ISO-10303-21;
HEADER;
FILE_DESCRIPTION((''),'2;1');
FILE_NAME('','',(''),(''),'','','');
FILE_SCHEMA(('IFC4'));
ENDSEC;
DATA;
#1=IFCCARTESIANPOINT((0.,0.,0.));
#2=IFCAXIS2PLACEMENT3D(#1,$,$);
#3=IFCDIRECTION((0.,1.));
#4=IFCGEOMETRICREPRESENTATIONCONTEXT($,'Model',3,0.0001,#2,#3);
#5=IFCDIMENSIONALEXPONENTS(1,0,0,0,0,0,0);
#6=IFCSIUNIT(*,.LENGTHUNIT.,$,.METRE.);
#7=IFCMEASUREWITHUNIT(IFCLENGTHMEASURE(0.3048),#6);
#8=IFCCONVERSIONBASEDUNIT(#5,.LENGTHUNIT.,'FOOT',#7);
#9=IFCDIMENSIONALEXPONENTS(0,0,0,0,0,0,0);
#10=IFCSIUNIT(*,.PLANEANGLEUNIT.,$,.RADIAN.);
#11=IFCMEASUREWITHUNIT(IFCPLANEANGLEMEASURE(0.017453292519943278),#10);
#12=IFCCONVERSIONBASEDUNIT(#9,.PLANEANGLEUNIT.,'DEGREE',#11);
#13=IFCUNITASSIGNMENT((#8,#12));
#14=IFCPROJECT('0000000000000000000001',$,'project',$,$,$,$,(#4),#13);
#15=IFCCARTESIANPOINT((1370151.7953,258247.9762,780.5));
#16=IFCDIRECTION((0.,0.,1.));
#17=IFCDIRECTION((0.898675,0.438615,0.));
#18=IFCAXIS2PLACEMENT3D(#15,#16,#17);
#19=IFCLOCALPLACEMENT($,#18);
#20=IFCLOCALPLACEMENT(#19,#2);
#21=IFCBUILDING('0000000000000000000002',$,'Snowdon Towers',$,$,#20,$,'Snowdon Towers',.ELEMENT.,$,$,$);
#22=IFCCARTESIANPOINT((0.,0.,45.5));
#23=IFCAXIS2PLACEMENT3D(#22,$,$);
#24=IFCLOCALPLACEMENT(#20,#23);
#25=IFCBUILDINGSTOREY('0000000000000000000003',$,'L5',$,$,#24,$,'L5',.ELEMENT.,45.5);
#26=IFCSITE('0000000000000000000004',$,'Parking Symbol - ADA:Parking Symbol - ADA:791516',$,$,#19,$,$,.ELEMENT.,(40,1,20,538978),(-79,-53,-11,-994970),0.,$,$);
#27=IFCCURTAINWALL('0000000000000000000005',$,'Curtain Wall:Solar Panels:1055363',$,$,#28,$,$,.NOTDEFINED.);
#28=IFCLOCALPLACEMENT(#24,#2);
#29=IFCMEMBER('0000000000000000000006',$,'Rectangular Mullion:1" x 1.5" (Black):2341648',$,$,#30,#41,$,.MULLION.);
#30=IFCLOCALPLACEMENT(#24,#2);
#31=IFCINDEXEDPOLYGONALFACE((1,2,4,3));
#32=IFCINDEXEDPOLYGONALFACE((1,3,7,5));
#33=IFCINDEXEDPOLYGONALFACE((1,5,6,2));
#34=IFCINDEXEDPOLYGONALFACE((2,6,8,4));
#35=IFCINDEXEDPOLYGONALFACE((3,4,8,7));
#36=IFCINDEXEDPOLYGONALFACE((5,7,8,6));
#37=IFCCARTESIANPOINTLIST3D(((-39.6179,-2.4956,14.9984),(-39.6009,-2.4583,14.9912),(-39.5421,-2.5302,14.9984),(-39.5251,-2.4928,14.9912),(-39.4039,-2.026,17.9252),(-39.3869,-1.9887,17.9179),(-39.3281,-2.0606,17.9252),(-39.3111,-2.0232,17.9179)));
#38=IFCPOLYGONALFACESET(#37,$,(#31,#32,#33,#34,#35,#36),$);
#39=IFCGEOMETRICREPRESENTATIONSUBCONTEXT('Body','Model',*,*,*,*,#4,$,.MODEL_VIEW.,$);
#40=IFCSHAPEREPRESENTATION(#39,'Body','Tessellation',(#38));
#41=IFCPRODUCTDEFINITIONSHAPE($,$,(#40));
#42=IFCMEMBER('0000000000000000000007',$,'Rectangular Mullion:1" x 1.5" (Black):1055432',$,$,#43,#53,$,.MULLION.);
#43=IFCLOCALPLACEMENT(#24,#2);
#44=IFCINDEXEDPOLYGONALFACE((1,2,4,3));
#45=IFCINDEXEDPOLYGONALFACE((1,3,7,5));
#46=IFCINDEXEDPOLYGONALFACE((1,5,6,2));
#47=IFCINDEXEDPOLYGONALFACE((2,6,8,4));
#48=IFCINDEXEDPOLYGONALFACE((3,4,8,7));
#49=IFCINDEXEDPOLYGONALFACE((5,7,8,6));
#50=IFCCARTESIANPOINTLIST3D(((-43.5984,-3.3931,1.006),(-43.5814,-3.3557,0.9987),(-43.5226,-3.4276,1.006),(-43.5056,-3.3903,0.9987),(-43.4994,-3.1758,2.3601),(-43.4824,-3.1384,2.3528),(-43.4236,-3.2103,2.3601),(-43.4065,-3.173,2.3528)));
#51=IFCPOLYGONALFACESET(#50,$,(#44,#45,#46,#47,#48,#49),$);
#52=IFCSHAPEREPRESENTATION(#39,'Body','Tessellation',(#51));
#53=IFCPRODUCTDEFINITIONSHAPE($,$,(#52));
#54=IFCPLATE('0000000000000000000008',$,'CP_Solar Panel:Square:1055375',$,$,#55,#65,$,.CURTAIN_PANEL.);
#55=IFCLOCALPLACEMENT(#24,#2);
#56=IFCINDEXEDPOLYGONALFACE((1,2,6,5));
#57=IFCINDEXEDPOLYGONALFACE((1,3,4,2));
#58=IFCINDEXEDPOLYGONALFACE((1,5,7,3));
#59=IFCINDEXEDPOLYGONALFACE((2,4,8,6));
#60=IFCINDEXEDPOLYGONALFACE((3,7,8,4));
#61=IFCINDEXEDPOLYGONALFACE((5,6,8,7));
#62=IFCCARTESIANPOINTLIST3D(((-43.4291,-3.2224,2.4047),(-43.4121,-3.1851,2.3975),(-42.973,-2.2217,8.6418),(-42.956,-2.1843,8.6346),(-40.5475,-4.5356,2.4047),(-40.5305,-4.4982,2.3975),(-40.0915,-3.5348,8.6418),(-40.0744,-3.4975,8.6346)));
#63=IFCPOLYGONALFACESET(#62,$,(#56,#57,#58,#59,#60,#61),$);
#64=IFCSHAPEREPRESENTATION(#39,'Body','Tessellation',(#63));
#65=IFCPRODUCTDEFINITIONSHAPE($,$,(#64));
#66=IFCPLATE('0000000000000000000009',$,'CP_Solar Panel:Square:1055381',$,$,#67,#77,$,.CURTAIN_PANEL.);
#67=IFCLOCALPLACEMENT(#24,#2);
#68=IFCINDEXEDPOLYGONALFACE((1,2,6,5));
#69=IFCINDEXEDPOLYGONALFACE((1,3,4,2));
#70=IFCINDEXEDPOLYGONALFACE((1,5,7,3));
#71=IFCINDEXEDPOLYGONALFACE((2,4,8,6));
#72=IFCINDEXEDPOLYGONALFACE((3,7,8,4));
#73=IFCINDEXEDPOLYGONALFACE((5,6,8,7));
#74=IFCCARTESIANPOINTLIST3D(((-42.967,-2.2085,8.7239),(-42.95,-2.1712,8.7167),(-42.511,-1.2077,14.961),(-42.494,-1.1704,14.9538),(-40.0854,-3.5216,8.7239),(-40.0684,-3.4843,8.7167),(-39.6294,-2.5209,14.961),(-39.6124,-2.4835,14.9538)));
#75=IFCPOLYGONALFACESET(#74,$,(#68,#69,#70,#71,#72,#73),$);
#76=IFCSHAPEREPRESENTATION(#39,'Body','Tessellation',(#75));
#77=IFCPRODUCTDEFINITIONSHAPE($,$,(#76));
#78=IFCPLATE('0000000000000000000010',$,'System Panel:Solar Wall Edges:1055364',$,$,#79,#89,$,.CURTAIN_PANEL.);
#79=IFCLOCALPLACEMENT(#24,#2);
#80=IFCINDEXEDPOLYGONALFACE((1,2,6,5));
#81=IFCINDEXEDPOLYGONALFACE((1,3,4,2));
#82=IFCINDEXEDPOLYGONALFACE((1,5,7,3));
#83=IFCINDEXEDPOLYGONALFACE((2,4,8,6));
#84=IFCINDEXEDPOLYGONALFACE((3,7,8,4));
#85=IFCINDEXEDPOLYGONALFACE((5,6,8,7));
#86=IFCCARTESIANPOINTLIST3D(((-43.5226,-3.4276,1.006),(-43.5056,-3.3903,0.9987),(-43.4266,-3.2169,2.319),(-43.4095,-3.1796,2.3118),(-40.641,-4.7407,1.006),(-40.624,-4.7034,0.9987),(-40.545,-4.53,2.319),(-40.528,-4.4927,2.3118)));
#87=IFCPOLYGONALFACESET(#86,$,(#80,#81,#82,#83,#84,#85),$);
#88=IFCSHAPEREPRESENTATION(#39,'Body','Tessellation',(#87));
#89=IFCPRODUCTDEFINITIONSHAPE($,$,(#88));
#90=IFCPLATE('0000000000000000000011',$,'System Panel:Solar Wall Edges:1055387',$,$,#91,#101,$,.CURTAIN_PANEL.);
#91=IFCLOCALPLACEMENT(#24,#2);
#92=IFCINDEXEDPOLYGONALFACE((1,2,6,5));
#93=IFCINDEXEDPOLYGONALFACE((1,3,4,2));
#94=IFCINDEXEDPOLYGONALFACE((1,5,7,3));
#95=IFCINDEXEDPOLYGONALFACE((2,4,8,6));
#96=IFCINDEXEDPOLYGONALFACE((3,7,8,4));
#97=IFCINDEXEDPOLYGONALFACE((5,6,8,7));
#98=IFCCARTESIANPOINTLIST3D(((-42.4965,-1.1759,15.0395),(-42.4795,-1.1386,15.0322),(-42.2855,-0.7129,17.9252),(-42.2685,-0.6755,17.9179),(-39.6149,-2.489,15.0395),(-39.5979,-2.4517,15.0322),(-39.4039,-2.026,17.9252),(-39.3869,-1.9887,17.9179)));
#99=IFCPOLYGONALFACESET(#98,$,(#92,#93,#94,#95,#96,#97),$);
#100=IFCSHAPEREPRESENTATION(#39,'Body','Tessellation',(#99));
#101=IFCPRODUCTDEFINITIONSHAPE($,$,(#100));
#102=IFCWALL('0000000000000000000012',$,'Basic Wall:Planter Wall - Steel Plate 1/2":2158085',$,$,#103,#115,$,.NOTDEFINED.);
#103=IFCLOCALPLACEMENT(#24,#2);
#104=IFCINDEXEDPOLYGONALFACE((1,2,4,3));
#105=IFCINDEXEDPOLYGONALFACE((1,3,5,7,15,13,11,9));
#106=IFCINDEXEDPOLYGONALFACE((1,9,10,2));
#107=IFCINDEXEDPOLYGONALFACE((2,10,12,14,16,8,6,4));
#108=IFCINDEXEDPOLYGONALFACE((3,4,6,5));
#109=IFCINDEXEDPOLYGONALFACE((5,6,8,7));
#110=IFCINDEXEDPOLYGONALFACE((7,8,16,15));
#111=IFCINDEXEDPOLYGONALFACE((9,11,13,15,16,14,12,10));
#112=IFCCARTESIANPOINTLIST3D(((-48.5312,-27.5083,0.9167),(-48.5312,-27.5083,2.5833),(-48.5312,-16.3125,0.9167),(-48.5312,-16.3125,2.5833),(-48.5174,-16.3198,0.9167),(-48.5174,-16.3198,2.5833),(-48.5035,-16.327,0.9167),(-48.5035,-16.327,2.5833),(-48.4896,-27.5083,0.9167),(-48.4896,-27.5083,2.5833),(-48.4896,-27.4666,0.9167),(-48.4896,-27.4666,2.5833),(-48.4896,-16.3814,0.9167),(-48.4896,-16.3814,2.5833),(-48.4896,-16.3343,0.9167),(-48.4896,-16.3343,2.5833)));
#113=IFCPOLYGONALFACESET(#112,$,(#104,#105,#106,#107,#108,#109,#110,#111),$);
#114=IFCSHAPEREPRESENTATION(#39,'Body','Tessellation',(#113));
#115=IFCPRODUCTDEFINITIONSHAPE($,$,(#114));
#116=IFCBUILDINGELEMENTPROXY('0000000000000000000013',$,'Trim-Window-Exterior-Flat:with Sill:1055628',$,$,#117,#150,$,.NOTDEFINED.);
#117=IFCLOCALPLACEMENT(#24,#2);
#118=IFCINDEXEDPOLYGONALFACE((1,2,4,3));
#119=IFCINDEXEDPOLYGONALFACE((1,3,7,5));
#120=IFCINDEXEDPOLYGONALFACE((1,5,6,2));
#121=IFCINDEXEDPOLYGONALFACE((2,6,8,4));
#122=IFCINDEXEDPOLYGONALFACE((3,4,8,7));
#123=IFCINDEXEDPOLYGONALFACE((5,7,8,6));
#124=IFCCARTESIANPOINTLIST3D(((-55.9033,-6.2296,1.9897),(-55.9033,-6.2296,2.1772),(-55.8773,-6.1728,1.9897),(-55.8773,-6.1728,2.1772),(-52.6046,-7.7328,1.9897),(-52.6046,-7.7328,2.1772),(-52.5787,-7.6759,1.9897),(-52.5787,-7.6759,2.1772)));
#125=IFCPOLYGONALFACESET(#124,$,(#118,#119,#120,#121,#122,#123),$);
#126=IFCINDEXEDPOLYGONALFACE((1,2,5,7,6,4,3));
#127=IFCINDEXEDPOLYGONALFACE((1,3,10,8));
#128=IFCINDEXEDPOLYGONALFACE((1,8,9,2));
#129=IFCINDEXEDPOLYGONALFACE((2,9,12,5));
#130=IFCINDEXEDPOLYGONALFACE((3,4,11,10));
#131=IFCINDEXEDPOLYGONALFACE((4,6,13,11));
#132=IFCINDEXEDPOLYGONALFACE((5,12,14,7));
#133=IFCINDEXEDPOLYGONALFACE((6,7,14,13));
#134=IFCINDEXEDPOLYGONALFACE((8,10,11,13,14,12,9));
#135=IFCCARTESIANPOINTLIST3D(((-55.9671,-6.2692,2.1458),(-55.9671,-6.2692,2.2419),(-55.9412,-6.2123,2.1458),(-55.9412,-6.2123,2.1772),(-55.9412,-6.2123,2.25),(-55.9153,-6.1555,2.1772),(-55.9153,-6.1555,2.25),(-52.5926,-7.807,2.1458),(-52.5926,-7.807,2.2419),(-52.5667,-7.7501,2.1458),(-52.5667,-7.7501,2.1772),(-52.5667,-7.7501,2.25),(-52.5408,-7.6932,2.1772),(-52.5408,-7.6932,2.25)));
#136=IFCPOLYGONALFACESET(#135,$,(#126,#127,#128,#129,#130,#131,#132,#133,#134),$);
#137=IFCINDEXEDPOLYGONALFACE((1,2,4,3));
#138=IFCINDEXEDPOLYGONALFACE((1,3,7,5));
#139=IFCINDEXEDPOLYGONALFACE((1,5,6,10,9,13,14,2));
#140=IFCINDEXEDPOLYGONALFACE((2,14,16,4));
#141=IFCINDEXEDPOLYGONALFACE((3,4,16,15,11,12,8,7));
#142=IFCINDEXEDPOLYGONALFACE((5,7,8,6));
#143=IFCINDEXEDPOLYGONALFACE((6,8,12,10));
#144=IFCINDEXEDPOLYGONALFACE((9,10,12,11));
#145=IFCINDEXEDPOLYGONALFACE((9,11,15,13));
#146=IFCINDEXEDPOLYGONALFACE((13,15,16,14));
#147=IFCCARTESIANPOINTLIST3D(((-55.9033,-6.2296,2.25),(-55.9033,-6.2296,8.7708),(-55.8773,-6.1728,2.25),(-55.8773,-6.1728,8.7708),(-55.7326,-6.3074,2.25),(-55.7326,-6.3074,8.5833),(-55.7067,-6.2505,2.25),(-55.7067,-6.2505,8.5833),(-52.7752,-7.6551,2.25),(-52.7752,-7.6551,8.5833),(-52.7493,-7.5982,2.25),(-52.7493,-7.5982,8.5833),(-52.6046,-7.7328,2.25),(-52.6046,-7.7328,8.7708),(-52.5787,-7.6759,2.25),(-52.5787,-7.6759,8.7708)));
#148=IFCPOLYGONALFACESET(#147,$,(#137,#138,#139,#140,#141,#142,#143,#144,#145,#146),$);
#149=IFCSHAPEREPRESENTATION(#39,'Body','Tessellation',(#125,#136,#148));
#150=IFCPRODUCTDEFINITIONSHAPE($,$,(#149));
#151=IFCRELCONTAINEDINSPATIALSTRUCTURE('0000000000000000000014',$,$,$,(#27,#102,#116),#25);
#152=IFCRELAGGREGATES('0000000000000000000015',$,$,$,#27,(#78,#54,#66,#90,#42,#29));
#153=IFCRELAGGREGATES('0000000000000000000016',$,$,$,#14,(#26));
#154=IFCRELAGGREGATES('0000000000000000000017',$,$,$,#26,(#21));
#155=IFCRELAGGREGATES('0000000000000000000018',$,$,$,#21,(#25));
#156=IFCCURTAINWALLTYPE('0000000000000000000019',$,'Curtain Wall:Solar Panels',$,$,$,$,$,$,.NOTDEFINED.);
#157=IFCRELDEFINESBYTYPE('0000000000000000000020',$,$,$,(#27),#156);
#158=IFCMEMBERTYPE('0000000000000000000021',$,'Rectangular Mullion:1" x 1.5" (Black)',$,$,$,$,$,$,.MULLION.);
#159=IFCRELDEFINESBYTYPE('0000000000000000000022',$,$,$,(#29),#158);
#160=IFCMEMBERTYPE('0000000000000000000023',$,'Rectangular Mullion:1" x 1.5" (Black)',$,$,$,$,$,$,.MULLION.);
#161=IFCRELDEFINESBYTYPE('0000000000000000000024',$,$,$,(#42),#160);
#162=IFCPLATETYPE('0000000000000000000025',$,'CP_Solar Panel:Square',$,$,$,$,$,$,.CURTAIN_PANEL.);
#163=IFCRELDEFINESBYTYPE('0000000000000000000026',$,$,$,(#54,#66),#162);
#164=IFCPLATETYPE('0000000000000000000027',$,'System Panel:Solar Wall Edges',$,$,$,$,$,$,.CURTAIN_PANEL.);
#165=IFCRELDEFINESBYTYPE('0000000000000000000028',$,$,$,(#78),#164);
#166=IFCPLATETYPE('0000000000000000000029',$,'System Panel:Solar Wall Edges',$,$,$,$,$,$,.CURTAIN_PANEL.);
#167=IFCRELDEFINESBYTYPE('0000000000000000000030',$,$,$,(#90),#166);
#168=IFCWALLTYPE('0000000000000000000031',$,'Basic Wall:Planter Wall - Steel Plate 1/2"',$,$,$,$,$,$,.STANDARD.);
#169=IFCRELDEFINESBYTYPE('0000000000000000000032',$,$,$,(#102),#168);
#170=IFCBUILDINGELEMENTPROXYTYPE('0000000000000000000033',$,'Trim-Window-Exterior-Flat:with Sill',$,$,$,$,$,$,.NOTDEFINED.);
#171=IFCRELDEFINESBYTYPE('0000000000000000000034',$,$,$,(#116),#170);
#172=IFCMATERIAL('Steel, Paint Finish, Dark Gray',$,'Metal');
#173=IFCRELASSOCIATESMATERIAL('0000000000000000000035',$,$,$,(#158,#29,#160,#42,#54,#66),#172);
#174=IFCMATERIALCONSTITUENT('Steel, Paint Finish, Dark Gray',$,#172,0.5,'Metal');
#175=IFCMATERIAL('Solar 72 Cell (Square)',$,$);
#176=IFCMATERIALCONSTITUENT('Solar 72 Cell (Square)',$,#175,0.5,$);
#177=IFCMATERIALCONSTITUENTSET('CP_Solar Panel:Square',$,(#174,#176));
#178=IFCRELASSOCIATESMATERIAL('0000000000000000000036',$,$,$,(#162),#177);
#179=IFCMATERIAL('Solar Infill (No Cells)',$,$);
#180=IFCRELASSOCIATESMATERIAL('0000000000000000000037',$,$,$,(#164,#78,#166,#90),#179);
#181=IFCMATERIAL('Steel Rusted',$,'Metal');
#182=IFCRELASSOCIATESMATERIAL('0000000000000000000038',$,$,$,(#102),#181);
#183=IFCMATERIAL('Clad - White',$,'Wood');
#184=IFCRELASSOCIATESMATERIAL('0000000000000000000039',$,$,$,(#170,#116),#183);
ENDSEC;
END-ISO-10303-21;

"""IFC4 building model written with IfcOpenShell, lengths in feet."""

from ifc_helpers import new_model, entity, si_unit, converted_unit, direction, frame, origin, place, context, subcontext, project, spatial, line, arc, indexed_curve, outline, extrude, source, transform, mapped, material, constituent, constituent_set, type_object, type_shapes, element, aggregate, save


model = new_model("IFC4")

# Units and contexts
model_context = context("Model", 3, precision=0.0001, world=origin(), true_north=direction((0.0, 1.0)))
body_context = subcontext(model_context, "Body", "Model", "MODEL_VIEW")
ifc_project = project(units=[converted_unit("LENGTHUNIT", "FOOT", entity("IfcLengthMeasure", 0.3048), si_unit("LENGTHUNIT", "METRE"), dimensions=[1, 0, 0, 0, 0, 0, 0]), converted_unit("PLANEANGLEUNIT", "DEGREE", entity("IfcPlaneAngleMeasure", 0.017453292519943278), si_unit("PLANEANGLEUNIT", "RADIAN"), dimensions=[0, 0, 0, 0, 0, 0, 0])], contexts=[model_context])

# Site, building, storey
site_placement = place(None, frame((1370151.7953, 258247.9762, 780.5), z_axis=(0.0, 0.0, 1.0), x_axis=(0.898675, 0.438615, 0.0)))
site = spatial("IfcSite", under=ifc_project, at=site_placement, Name="Parking Symbol - ADA:Parking Symbol - ADA:791516", CompositionType="ELEMENT", RefLatitude=(40, 1, 20, 538978), RefLongitude=(-79, -53, -11, -994970), RefElevation=0.0)
building_placement = place(site_placement, origin())
building = spatial("IfcBuilding", under=site, at=building_placement, Name="Snowdon Towers", LongName="Snowdon Towers", CompositionType="ELEMENT")
storey_placement = place(building_placement, frame((0.0, 0.0, 45.5)))
storey = spatial("IfcBuildingStorey", under=building, at=storey_placement, Name="L5", LongName="L5", CompositionType="ELEMENT", Elevation=45.5)

# Curtain wall, members, plates
curtain_wall_type = type_object("IfcCurtainWallType", Name="Curtain Wall:Solar Panels", PredefinedType="NOTDEFINED")
curtain_wall_placement = place(storey_placement, frame((0.0, 0.0, -45.5)))
curtain_wall = element("IfcCurtainWall", 1, at=curtain_wall_placement, inside=storey, type_object=curtain_wall_type, Name="Curtain Wall:Solar Panels:1055363", PredefinedType="NOTDEFINED")
ifc_material_1 = material(Name="Steel, Paint Finish, Dark Gray", Category="Metal")
member_type_1 = type_object("IfcMemberType", Name="Rectangular Mullion:1\" x 1.5\" (Black)", PredefinedType="MULLION", material=ifc_material_1)
shared_shape_1 = source(origin(), body_context, "Body", "SweptSolid", [
    extrude(outline(indexed_curve([(-0.0417, -0.0208), (0.0417, -0.0208), (0.0417, 0.0208), (-0.0417, 0.0208), (-0.0417, -0.0208)], self_intersect=False)), frame((0.0, 0.0208, -2.9719), z_axis=(0.0, 0.0, 1.0), x_axis=(-1.0, 0.0, 0.0)), (0.0, 0.0, 1.0), 2.9719),
])
type_shapes(member_type_1, [shared_shape_1])
member_1_placement = place(curtain_wall_placement, frame((-39.563, -2.4755, 60.4912), z_axis=(-0.072007, -0.158015, -0.984808), x_axis=(0.909972, -0.414671, 0.0)))
member_1 = element("IfcMember", 2, at=member_1_placement, type_object=member_type_1, material=ifc_material_1, Name="Rectangular Mullion:1\" x 1.5\" (Black):2341648", PredefinedType="MULLION", context=body_context, shape_type="MappedRepresentation", body=[
    mapped(shared_shape_1, transform((0.0, 0.0, 0.0), scale=1.0)),
])
member_type_2 = type_object("IfcMemberType", Name="Rectangular Mullion:1\" x 1.5\" (Black)", PredefinedType="MULLION", material=ifc_material_1)
shared_shape_2 = source(origin(), body_context, "Body", "SweptSolid", [
    extrude(outline(indexed_curve([(-0.0417, -0.0208), (0.0417, -0.0208), (0.0417, 0.0208), (-0.0417, 0.0208), (-0.0417, -0.0208)], self_intersect=False)), frame((-0.0417, 0.0208, -1.375), z_axis=(0.0, 0.0, 1.0), x_axis=(-1.0, 0.0, 0.0)), (0.0, 0.0, 1.0), 1.375),
])
type_shapes(member_type_2, [shared_shape_2])
member_2_placement = place(curtain_wall_placement, frame((-43.4824, -3.1384, 47.8528), z_axis=(0.072007, 0.158015, 0.984808), x_axis=(-0.909972, 0.414671, 0.0)))
member_2 = element("IfcMember", 3, at=member_2_placement, type_object=member_type_2, material=ifc_material_1, Name="Rectangular Mullion:1\" x 1.5\" (Black):1055432", PredefinedType="MULLION", context=body_context, shape_type="MappedRepresentation", body=[
    mapped(shared_shape_2, transform((0.0, 0.0, 0.0), scale=1.0)),
])
ifc_constituent_1 = constituent(ifc_material_1, Name="Steel, Paint Finish, Dark Gray", Category="Metal", fraction=0.5)
ifc_material_2 = material(Name="Solar 72 Cell (Square)")
ifc_constituent_2 = constituent(ifc_material_2, Name="Solar 72 Cell (Square)", fraction=0.5)
ifc_constituent_set_1 = constituent_set(constituents=[ifc_constituent_1, ifc_constituent_2], Name="CP_Solar Panel:Square")
plate_type_1 = type_object("IfcPlateType", Name="CP_Solar Panel:Square", PredefinedType="CURTAIN_PANEL", material=ifc_constituent_set_1)
shared_shape_3 = source(origin(), body_context, "Body", "SweptSolid", [
    extrude(outline(indexed_curve([(-1.5833, -0.0208), (1.5833, -0.0208), (1.5833, 0.0208), (-1.5833, 0.0208), (-1.5833, -0.0208)], self_intersect=False)), frame((0.0, -0.0417, 0.0)), (0.0, 0.0, 1.0), 6.3333),
])
type_shapes(plate_type_1, [shared_shape_3])
plate_1_placement = place(curtain_wall_placement, frame((-41.9628, -3.823, 47.8939), z_axis=(0.072007, 0.158015, 0.984808), x_axis=(0.909972, -0.414671, 0.0)))
plate_1 = element("IfcPlate", 4, at=plate_1_placement, type_object=plate_type_1, material=ifc_material_1, Name="CP_Solar Panel:Square:1055375", PredefinedType="CURTAIN_PANEL", context=body_context, shape_type="MappedRepresentation", body=[
    mapped(shared_shape_3, transform((0.0, 0.0, 0.0), scale=1.0)),
])
plate_2_placement = place(curtain_wall_placement, frame((-41.5007, -2.8091, 54.2131), z_axis=(0.072007, 0.158015, 0.984808), x_axis=(0.909972, -0.414671, 0.0)))
plate_2 = element("IfcPlate", 5, at=plate_2_placement, type_object=plate_type_1, material=ifc_material_1, Name="CP_Solar Panel:Square:1055381", PredefinedType="CURTAIN_PANEL", context=body_context, shape_type="MappedRepresentation", body=[
    mapped(shared_shape_3, transform((0.0, 0.0, 0.0), scale=1.0)),
])
ifc_material_3 = material(Name="Solar Infill (No Cells)")
plate_type_2 = type_object("IfcPlateType", Name="System Panel:Solar Wall Edges", PredefinedType="CURTAIN_PANEL", material=ifc_material_3)
shared_shape_4 = source(origin(), body_context, "Body", "SweptSolid", [
    extrude(outline(indexed_curve([(-0.0208, -1.5833), (0.0208, -1.5833), (0.0208, 1.5833), (-0.0208, 1.5833), (-0.0208, -1.5833)], self_intersect=False)), frame((0.0, -0.0208, 0.0), z_axis=(0.0, 0.0, 1.0), x_axis=(0.0, 1.0, 0.0)), (0.0, 0.0, 1.0), 1.3333),
])
type_shapes(plate_type_2, [shared_shape_4])
plate_3_placement = place(curtain_wall_placement, frame((-42.0648, -4.0468, 46.4987), z_axis=(0.072007, 0.158015, 0.984808), x_axis=(0.909972, -0.414671, 0.0)))
plate_3 = element("IfcPlate", 6, at=plate_3_placement, type_object=plate_type_2, material=ifc_material_3, Name="System Panel:Solar Wall Edges:1055364", PredefinedType="CURTAIN_PANEL", context=body_context, shape_type="MappedRepresentation", body=[
    mapped(shared_shape_4, transform((0.0, 0.0, 0.0), scale=1.0)),
])
plate_type_3 = type_object("IfcPlateType", Name="System Panel:Solar Wall Edges", PredefinedType="CURTAIN_PANEL", material=ifc_material_3)
shared_shape_5 = source(origin(), body_context, "Body", "SweptSolid", [
    extrude(outline(indexed_curve([(-0.0208, -1.5833), (0.0208, -1.5833), (0.0208, 1.5833), (-0.0208, 1.5833), (-0.0208, -1.5833)], self_intersect=False)), frame((0.0, -0.0208, 0.0), z_axis=(0.0, 0.0, 1.0), x_axis=(0.0, 1.0, 0.0)), (0.0, 0.0, 1.0), 2.9302),
])
type_shapes(plate_type_3, [shared_shape_5])
plate_4_placement = place(curtain_wall_placement, frame((-41.0387, -1.7951, 60.5322), z_axis=(0.072007, 0.158015, 0.984808), x_axis=(0.909972, -0.414671, 0.0)))
plate_4 = element("IfcPlate", 7, at=plate_4_placement, type_object=plate_type_3, material=ifc_material_3, Name="System Panel:Solar Wall Edges:1055387", PredefinedType="CURTAIN_PANEL", context=body_context, shape_type="MappedRepresentation", body=[
    mapped(shared_shape_5, transform((0.0, 0.0, 0.0), scale=1.0)),
])
aggregate(curtain_wall, [plate_3, plate_1, plate_2, plate_4, member_2, member_1])

# Wall
ifc_material_4 = material(Name="Steel Rusted", Category="Metal")
wall_type_1 = type_object("IfcWallType", Name="Basic Wall:Planter Wall - Steel Plate 1/2\"", PredefinedType="STANDARD")
wall_1_placement = place(storey_placement, frame((-48.5104, -16.3125, 0.9167), z_axis=(0.0, 0.0, 1.0), x_axis=(0.0, -1.0, 0.0)))
element("IfcWall", 8, at=wall_1_placement, inside=storey, type_object=wall_type_1, material=ifc_material_4, Name="Basic Wall:Planter Wall - Steel Plate 1/2\":2158085", PredefinedType="NOTDEFINED", context=body_context, shape_type="SweptSolid", body=[
    extrude(outline(indexed_curve([(11.1958, -0.0208), (11.1958, 0.0208), (11.1541, 0.0208), (0.0689, 0.0208), (0.0218, 0.0208), (0.0109, 0.0), (0.0, -0.0208)], segments=[line(1, 2, 3, 4, 5), arc(5, 6, 7), line(7, 1)], self_intersect=False)), origin(), (0.0, 0.0, 1.0), 1.6667),
])

# Building element proxy
ifc_material_5 = material(Name="Clad - White", Category="Wood")
building_element_proxy_type = type_object("IfcBuildingElementProxyType", Name="Trim-Window-Exterior-Flat:with Sill", PredefinedType="NOTDEFINED", material=ifc_material_5)
shared_shape_6 = source(origin(), body_context, "Body", "SweptSolid", [
    extrude(outline(indexed_curve([(-1.8125, -0.0938), (1.8125, -0.0938), (1.8125, 0.0938), (-1.8125, 0.0938), (-1.8125, -0.0938)], self_intersect=False)), frame((0.0, -6.4999, 0.0), z_axis=(0.0, 0.0, 1.0), x_axis=(-1.0, 0.0, 0.0)), (0.0, 0.0, 1.0), 0.0625),
    extrude(outline(indexed_curve([(-0.0625, -0.0525), (0.0, -0.0525), (0.0, -0.0211), (0.0625, -0.0211), (0.0625, 0.0517), (0.0, 0.0517), (-0.0625, 0.0436), (-0.0625, -0.0525)], self_intersect=False)), frame((-1.8542, -6.385, 0.0625), z_axis=(1.0, 0.0, 0.0), x_axis=(0.0, 0.0, -1.0)), (0.0, 0.0, 1.0), 3.7083),
    extrude(outline(indexed_curve([(-3.3073, -1.8125), (3.2135, -1.8125), (3.2135, -1.625), (-3.1198, -1.625), (-3.1198, 1.625), (3.2135, 1.625), (3.2135, 1.8125), (-3.3073, 1.8125), (-3.3073, -1.8125)], self_intersect=False)), frame((0.0, -3.1198, 0.0), z_axis=(0.0, 0.0, 1.0), x_axis=(0.0, -1.0, 0.0)), (0.0, 0.0, 1.0), 0.0625),
])
type_shapes(building_element_proxy_type, [shared_shape_6])
proxy_placement = place(storey_placement, frame((-54.228, -6.9243, 8.5833), z_axis=(-0.414671, -0.909972, 0.0), x_axis=(0.909972, -0.414671, 0.0)))
element("IfcBuildingElementProxy", 9, at=proxy_placement, inside=storey, type_object=building_element_proxy_type, material=ifc_material_5, Name="Trim-Window-Exterior-Flat:with Sill:1055628", PredefinedType="NOTDEFINED", context=body_context, shape_type="MappedRepresentation", body=[
    mapped(shared_shape_6, transform((0.0, 0.0, 0.0), scale=1.0)),
])

save(model, "model.ifc")
